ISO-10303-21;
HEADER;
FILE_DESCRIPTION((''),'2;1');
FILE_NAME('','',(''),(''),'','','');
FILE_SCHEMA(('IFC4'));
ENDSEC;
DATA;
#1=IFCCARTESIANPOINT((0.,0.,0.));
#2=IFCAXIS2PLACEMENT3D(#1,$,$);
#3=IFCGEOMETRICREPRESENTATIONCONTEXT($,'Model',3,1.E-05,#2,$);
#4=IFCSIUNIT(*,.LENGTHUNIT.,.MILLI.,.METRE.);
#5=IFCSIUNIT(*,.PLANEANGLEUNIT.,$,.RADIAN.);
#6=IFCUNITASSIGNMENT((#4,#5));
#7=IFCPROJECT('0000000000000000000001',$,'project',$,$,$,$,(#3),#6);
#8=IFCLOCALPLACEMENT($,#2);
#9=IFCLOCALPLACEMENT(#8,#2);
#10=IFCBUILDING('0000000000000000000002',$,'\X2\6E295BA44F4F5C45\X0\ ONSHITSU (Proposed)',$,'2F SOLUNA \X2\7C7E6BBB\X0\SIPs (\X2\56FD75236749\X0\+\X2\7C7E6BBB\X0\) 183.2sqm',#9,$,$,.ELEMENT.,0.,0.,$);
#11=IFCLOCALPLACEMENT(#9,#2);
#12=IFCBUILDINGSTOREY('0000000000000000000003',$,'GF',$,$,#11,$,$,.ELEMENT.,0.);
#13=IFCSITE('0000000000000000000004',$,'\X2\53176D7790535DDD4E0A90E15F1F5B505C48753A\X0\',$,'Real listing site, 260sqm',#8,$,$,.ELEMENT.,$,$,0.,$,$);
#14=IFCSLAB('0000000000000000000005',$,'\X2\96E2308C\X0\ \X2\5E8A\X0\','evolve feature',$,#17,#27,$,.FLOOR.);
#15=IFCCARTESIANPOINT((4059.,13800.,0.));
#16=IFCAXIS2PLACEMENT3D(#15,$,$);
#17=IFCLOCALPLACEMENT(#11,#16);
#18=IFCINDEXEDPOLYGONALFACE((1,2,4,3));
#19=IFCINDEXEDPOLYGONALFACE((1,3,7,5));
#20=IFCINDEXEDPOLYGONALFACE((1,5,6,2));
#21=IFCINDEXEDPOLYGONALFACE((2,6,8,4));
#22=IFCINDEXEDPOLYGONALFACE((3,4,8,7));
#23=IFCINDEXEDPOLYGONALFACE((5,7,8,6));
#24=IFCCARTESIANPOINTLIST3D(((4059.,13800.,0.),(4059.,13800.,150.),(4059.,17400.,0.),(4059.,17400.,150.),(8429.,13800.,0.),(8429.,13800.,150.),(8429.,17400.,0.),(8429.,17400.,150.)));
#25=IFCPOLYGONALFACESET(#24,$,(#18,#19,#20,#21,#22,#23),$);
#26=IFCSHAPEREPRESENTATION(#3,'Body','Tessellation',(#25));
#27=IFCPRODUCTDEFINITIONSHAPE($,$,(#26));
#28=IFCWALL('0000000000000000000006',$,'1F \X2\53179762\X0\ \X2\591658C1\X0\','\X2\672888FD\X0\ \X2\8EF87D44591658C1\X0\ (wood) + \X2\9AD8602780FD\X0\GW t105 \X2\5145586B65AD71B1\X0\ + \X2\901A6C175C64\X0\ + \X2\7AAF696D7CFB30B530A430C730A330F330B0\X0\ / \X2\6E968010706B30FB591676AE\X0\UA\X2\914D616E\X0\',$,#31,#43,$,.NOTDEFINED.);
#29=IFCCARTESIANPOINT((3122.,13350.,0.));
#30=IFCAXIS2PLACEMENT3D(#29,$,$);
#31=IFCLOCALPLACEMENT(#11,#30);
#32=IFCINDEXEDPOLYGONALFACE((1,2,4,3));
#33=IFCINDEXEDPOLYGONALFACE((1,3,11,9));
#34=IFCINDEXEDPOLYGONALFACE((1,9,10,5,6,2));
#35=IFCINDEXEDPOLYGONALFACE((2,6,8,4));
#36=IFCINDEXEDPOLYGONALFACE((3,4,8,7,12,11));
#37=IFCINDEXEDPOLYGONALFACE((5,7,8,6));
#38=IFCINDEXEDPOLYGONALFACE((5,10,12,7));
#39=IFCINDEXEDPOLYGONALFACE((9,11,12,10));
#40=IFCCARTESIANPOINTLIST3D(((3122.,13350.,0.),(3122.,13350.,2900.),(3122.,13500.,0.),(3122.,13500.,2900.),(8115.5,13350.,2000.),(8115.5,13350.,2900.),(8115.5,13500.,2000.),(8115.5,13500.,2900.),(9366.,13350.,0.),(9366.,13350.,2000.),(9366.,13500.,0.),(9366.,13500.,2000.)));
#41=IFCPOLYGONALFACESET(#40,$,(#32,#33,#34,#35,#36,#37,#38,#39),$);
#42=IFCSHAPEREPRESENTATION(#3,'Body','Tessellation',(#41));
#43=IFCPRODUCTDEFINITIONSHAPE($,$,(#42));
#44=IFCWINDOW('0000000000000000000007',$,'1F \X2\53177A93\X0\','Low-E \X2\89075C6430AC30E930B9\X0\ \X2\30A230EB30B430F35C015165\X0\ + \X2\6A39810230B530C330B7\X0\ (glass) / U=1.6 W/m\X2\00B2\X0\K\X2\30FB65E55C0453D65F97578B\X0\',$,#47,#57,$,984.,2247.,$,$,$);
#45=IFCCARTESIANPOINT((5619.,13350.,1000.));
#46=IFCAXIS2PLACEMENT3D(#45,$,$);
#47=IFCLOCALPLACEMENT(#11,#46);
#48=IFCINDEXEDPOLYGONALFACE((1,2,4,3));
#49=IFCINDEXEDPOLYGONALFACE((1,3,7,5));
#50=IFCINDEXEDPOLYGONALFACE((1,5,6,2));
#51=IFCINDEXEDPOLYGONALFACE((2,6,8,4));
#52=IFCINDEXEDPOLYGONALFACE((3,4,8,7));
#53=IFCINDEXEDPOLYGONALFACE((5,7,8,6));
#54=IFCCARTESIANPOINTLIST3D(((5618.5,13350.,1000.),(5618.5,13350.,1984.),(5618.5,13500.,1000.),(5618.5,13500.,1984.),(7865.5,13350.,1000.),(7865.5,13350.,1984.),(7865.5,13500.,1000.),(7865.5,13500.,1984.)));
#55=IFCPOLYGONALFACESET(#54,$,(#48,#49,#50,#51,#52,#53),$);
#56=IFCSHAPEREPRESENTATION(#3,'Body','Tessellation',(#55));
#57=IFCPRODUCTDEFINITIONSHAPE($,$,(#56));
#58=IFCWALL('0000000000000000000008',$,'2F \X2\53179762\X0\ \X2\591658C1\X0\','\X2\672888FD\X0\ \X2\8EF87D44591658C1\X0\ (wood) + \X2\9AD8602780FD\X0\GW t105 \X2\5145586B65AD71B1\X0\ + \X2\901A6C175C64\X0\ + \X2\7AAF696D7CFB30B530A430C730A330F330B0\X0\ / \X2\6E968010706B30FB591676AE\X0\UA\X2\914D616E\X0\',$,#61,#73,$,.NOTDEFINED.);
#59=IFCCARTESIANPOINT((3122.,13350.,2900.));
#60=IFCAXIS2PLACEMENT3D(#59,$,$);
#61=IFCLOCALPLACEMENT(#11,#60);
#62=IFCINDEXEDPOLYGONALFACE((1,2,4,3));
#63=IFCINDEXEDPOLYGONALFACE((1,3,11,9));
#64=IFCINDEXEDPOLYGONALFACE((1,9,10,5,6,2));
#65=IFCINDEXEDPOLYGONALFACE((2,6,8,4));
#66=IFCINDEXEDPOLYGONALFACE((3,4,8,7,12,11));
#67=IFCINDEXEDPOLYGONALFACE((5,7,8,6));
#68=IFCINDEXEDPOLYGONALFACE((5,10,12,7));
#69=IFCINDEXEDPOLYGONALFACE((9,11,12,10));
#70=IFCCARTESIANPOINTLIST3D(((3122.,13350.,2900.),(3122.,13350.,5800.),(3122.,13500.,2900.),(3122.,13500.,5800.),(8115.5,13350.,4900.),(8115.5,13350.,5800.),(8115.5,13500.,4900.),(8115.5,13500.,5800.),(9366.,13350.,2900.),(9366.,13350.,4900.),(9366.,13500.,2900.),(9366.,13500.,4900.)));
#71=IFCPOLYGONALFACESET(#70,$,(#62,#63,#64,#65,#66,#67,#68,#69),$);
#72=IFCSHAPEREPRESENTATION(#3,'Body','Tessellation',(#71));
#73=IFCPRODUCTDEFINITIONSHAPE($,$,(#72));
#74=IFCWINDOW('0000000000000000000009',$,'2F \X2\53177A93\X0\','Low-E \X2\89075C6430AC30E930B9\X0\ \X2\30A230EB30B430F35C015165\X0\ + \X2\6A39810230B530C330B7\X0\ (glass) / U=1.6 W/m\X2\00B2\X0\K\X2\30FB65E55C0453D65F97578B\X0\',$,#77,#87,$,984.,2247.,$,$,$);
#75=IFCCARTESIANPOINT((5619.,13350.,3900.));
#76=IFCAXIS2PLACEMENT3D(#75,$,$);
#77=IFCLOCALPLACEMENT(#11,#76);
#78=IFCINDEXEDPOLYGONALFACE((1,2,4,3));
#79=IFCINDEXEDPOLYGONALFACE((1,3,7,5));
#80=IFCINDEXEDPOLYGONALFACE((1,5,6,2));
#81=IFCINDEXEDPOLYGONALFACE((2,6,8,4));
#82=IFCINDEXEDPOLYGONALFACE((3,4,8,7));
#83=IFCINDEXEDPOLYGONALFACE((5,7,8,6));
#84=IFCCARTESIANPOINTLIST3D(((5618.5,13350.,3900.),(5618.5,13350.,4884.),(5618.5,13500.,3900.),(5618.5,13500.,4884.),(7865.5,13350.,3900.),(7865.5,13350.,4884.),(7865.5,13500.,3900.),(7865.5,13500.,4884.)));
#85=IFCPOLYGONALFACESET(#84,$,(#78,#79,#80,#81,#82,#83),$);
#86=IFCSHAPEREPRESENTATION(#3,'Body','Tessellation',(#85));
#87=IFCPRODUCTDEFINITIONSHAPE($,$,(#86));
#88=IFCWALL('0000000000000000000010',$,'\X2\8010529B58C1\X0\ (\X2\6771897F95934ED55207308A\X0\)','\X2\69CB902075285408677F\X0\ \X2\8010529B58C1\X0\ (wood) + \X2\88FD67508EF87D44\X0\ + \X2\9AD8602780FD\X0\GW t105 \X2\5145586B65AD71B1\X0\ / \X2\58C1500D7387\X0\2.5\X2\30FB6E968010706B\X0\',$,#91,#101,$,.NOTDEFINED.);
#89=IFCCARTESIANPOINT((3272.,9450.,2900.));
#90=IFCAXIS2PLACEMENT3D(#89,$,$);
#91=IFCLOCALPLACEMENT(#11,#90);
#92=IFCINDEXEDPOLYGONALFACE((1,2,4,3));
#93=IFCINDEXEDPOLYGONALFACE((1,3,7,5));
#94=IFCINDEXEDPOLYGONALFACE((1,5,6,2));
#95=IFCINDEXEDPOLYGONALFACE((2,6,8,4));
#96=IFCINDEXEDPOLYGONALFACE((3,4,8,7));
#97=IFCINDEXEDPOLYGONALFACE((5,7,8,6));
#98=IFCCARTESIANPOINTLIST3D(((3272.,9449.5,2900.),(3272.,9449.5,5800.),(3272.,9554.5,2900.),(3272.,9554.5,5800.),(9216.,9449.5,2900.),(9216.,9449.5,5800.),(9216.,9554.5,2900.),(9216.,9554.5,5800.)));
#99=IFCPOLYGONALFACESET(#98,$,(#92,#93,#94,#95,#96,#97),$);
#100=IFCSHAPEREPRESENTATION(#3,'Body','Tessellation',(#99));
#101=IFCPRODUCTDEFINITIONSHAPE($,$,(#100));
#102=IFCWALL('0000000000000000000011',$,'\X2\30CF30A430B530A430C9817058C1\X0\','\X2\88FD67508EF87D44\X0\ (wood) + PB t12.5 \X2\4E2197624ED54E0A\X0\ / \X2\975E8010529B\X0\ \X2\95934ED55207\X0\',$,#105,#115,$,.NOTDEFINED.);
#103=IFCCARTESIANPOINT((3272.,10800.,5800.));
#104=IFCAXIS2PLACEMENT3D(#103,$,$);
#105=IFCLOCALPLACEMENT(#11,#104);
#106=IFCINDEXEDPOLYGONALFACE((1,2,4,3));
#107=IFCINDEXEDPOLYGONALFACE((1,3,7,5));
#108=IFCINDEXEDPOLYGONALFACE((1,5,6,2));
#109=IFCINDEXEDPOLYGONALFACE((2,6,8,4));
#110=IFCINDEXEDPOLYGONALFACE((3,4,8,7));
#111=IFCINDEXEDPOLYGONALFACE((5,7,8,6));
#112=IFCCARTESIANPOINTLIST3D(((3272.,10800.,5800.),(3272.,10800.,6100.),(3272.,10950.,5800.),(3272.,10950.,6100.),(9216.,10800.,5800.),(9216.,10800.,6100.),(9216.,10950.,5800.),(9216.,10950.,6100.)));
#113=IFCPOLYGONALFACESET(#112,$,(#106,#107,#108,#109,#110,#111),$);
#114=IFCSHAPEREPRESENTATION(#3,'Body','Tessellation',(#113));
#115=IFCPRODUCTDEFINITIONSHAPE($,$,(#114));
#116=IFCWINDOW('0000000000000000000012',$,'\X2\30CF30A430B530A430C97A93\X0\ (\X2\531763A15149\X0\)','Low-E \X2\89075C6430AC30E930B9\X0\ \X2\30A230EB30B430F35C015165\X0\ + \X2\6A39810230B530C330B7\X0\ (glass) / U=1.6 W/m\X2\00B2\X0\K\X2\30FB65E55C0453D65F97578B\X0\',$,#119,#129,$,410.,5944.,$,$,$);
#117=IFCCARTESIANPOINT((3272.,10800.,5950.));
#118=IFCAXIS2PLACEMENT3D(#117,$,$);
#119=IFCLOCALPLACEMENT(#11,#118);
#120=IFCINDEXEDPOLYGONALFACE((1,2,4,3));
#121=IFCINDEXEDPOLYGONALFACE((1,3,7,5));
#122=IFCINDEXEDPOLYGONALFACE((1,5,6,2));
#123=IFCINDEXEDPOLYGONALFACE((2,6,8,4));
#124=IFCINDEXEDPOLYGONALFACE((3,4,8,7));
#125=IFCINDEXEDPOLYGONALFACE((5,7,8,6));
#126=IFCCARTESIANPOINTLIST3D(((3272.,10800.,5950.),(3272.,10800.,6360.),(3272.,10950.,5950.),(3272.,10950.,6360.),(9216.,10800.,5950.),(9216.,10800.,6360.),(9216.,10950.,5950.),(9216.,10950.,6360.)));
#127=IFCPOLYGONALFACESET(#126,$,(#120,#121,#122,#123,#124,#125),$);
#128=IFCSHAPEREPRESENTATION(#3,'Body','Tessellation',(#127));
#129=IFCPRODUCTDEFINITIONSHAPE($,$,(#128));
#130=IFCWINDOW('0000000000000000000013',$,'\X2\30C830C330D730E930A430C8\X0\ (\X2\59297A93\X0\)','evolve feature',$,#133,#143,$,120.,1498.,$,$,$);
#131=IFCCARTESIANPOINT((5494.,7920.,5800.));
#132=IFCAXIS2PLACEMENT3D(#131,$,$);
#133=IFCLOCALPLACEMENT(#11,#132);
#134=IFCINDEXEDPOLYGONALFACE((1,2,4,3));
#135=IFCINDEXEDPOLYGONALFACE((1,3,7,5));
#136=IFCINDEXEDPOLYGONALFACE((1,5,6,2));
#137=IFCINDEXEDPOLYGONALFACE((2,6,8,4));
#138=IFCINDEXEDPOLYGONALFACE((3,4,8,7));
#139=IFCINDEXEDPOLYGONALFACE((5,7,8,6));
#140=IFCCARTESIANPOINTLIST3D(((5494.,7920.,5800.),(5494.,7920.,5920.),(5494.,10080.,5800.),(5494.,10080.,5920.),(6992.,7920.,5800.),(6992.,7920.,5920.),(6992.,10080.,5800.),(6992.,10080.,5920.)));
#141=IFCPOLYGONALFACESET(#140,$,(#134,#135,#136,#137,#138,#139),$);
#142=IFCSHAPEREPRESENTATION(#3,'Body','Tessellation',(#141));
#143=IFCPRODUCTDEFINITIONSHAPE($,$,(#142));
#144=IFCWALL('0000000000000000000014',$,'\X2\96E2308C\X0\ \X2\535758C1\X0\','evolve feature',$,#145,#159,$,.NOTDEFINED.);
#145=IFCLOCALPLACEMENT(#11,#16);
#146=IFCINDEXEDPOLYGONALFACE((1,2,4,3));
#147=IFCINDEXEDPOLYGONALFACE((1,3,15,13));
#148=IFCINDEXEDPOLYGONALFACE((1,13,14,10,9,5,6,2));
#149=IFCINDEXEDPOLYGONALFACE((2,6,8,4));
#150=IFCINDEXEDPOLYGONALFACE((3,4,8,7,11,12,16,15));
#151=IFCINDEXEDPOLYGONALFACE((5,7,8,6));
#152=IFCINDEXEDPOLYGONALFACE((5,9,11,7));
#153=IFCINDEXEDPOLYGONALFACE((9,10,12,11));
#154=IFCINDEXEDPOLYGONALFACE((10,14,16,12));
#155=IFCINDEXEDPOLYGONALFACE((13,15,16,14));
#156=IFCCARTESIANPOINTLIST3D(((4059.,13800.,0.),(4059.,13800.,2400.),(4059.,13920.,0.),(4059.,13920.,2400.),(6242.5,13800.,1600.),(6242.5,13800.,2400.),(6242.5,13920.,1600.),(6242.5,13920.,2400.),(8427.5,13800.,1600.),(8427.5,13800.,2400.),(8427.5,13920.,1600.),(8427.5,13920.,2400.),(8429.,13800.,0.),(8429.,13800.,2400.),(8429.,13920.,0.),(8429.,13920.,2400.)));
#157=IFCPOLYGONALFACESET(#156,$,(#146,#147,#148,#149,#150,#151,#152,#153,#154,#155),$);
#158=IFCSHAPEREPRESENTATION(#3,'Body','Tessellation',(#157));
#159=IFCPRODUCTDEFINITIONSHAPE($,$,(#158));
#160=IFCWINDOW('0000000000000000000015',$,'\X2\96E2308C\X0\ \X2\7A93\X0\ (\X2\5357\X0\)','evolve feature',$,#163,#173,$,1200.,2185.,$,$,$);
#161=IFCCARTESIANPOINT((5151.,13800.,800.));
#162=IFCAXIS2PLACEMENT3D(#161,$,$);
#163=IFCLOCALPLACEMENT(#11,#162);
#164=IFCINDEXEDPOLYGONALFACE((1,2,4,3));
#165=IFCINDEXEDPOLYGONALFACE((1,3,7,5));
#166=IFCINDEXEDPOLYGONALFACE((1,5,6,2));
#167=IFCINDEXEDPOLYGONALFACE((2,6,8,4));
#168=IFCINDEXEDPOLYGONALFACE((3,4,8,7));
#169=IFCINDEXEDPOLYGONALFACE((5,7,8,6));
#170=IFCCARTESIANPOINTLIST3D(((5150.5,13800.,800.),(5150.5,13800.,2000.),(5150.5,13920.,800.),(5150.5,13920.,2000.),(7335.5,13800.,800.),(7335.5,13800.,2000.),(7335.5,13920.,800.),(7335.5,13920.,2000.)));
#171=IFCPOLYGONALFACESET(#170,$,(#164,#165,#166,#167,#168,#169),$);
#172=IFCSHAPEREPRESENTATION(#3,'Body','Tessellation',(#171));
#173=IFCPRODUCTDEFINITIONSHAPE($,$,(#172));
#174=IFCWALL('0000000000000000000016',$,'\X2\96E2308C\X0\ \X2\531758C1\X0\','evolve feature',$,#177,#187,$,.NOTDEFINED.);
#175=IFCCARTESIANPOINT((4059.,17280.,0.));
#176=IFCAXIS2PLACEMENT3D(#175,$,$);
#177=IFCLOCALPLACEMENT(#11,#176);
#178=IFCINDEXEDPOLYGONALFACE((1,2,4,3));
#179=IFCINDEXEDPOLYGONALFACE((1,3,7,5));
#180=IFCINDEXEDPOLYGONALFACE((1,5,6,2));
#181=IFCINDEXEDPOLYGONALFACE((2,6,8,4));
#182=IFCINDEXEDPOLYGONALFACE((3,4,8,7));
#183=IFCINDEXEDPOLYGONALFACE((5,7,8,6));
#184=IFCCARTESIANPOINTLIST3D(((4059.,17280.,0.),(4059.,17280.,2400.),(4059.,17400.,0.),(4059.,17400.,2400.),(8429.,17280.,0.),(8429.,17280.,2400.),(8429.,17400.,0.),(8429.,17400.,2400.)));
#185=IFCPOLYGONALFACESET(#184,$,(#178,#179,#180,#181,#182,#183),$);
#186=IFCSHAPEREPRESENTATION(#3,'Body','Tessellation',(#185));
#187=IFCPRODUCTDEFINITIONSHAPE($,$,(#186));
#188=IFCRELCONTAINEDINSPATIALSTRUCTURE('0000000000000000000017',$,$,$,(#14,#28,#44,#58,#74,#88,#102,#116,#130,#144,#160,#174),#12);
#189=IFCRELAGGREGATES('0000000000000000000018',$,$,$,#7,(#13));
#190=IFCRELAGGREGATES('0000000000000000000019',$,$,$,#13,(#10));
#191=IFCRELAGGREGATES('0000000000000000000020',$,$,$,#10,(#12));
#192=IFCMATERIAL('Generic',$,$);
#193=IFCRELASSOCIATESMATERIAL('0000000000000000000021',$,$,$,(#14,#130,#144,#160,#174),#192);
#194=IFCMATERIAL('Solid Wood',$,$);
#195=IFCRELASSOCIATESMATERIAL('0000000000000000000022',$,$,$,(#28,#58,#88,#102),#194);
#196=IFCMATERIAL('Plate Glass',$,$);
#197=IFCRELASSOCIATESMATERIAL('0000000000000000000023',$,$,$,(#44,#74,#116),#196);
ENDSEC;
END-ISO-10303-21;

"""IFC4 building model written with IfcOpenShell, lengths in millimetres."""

from ifc_helpers import new_model, si_unit, frame, frame_2d, origin, place, context, project, spatial, rectangle, extrude, material, element, fill, save


model = new_model("IFC4")

# Units and contexts
model_context = context("Model", 3, precision=1e-05, world=origin())
ifc_project = project(units=[si_unit("LENGTHUNIT", "METRE", prefix="MILLI"), si_unit("PLANEANGLEUNIT", "RADIAN")], contexts=[model_context])

# Site, building, storey
site_placement = place(None, origin())
site = spatial("IfcSite", under=ifc_project, at=site_placement, Name="北海道川上郡弟子屈町", ObjectType="Real listing site, 260sqm", CompositionType="ELEMENT", RefElevation=0.0)
building_placement = place(site_placement, origin())
building = spatial("IfcBuilding", under=site, at=building_placement, Name="温室住居 ONSHITSU (Proposed)", ObjectType="2F SOLUNA 籾殻SIPs (国産杉+籾殻) 183.2sqm", CompositionType="ELEMENT", ElevationOfRefHeight=0.0, ElevationOfTerrain=0.0)
storey_placement = place(building_placement, origin())
storey = spatial("IfcBuildingStorey", under=building, at=storey_placement, Name="GF", CompositionType="ELEMENT", Elevation=0.0)

# Slab
ifc_material_1 = material(Name="Generic")
slab_placement = place(storey_placement, frame((4059.0, 13800.0, 0.0)))
element("IfcSlab", 1, at=slab_placement, inside=storey, material=ifc_material_1, Name="離れ 床", Description="evolve feature", PredefinedType="FLOOR", context=model_context, shape_type="SweptSolid", body=[
    extrude(rectangle(XDim=4370.0, YDim=3600.0, at=frame_2d((2185.0, 1800.0))), frame((4059.0, 13800.0, 0.0)), (0.0, 0.0, 1.0), 150.0),
])

# Wall, opening, window
ifc_material_2 = material(Name="Solid Wood")
wall_1_placement = place(storey_placement, frame((3122.0, 13350.0, 0.0)))
wall_1 = element("IfcWall", 2, at=wall_1_placement, inside=storey, material=ifc_material_2, Name="1F 北面 外壁", Description="木製 軸組外壁 (wood) + 高性能GW t105 充填断熱 + 通気層 + 窯業系サイディング / 準耐火・外皮UA配慮", PredefinedType="NOTDEFINED", context=model_context, shape_type="SweptSolid", body=[
    extrude(rectangle(XDim=6244.0, YDim=150.0, at=frame_2d((3122.0, 75.0))), frame((3122.0, 13350.0, 0.0)), (0.0, 0.0, 1.0), 2900.0),
])
opening_1_placement = place(storey_placement, frame((5619.0, 13350.0, 1000.0)))
opening_1 = element("IfcOpeningElement", 3, at=opening_1_placement, cuts=wall_1, PredefinedType="NOTDEFINED", context=model_context, shape_type="SweptSolid", body=[
    extrude(rectangle(XDim=2247.0, YDim=150.0, at=frame_2d((1123.0, 75.0))), frame((5619.0, 13350.0, 1000.0)), (0.0, 0.0, 1.0), 984.0),
])
ifc_material_3 = material(Name="Plate Glass")
window_1_placement = place(storey_placement, frame((5619.0, 13350.0, 1000.0)))
window_1 = element("IfcWindow", 4, at=window_1_placement, inside=storey, material=ifc_material_3, Name="1F 北窓", Description="Low-E 複層ガラス アルゴン封入 + 樹脂サッシ (glass) / U=1.6 W/m²K・日射取得型", OverallHeight=984.0, OverallWidth=2247.0, context=model_context, shape_type="SweptSolid", body=[
    extrude(rectangle(XDim=2247.0, YDim=150.0, at=frame_2d((1123.0, 75.0))), frame((5619.0, 13350.0, 1000.0)), (0.0, 0.0, 1.0), 984.0),
])
fill(opening_1, window_1)

# Wall, opening, window
wall_2_placement = place(storey_placement, frame((3122.0, 13350.0, 2900.0)))
wall_2 = element("IfcWall", 5, at=wall_2_placement, inside=storey, material=ifc_material_2, Name="2F 北面 外壁", Description="木製 軸組外壁 (wood) + 高性能GW t105 充填断熱 + 通気層 + 窯業系サイディング / 準耐火・外皮UA配慮", PredefinedType="NOTDEFINED", context=model_context, shape_type="SweptSolid", body=[
    extrude(rectangle(XDim=6244.0, YDim=150.0, at=frame_2d((3122.0, 75.0))), frame((3122.0, 13350.0, 2900.0)), (0.0, 0.0, 1.0), 2900.0),
])
opening_2_placement = place(storey_placement, frame((5619.0, 13350.0, 3900.0)))
opening_2 = element("IfcOpeningElement", 6, at=opening_2_placement, cuts=wall_2, PredefinedType="NOTDEFINED", context=model_context, shape_type="SweptSolid", body=[
    extrude(rectangle(XDim=2247.0, YDim=150.0, at=frame_2d((1123.0, 75.0))), frame((5619.0, 13350.0, 3900.0)), (0.0, 0.0, 1.0), 984.0),
])
window_2_placement = place(storey_placement, frame((5619.0, 13350.0, 3900.0)))
window_2 = element("IfcWindow", 7, at=window_2_placement, inside=storey, material=ifc_material_3, Name="2F 北窓", Description="Low-E 複層ガラス アルゴン封入 + 樹脂サッシ (glass) / U=1.6 W/m²K・日射取得型", OverallHeight=984.0, OverallWidth=2247.0, context=model_context, shape_type="SweptSolid", body=[
    extrude(rectangle(XDim=2247.0, YDim=150.0, at=frame_2d((1123.0, 75.0))), frame((5619.0, 13350.0, 3900.0)), (0.0, 0.0, 1.0), 984.0),
])
fill(opening_2, window_2)

# Wall
wall_3_placement = place(storey_placement, frame((3272.0, 9450.0, 2900.0)))
element("IfcWall", 8, at=wall_3_placement, inside=storey, material=ifc_material_2, Name="耐力壁 (東西間仕切り)", Description="構造用合板 耐力壁 (wood) + 製材軸組 + 高性能GW t105 充填断熱 / 壁倍率2.5・準耐火", PredefinedType="NOTDEFINED", context=model_context, shape_type="SweptSolid", body=[
    extrude(rectangle(XDim=5944.0, YDim=105.0, at=frame_2d((2972.0, 52.0))), frame((3272.0, 9450.0, 2900.0)), (0.0, 0.0, 1.0), 2900.0),
])

# Wall, opening, window
wall_4_placement = place(storey_placement, frame((3272.0, 10800.0, 5800.0)))
wall_4 = element("IfcWall", 9, at=wall_4_placement, inside=storey, material=ifc_material_2, Name="ハイサイド腰壁", Description="製材軸組 (wood) + PB t12.5 両面仕上 / 非耐力 間仕切", PredefinedType="NOTDEFINED", context=model_context, shape_type="SweptSolid", body=[
    extrude(rectangle(XDim=5944.0, YDim=150.0, at=frame_2d((2972.0, 75.0))), frame((3272.0, 10800.0, 5800.0)), (0.0, 0.0, 1.0), 700.0),
])
opening_3_placement = place(storey_placement, frame((3272.0, 10800.0, 5950.0)))
opening_3 = element("IfcOpeningElement", 10, at=opening_3_placement, cuts=wall_4, PredefinedType="NOTDEFINED", context=model_context, shape_type="SweptSolid", body=[
    extrude(rectangle(XDim=5944.0, YDim=150.0, at=frame_2d((2972.0, 75.0))), frame((3272.0, 10800.0, 5950.0)), (0.0, 0.0, 1.0), 410.0),
])
window_3_placement = place(storey_placement, frame((3272.0, 10800.0, 5950.0)))
window_3 = element("IfcWindow", 11, at=window_3_placement, inside=storey, material=ifc_material_3, Name="ハイサイド窓 (北採光)", Description="Low-E 複層ガラス アルゴン封入 + 樹脂サッシ (glass) / U=1.6 W/m²K・日射取得型", OverallHeight=410.0, OverallWidth=5944.0, context=model_context, shape_type="SweptSolid", body=[
    extrude(rectangle(XDim=5944.0, YDim=150.0, at=frame_2d((2972.0, 75.0))), frame((3272.0, 10800.0, 5950.0)), (0.0, 0.0, 1.0), 410.0),
])
fill(opening_3, window_3)

# Window
window_4_placement = place(storey_placement, frame((5494.0, 7920.0, 5800.0)))
element("IfcWindow", 12, at=window_4_placement, inside=storey, material=ifc_material_1, Name="トップライト (天窓)", Description="evolve feature", OverallHeight=120.0, OverallWidth=1498.0, context=model_context, shape_type="SweptSolid", body=[
    extrude(rectangle(XDim=1498.0, YDim=2160.0, at=frame_2d((749.0, 1080.0))), frame((5494.0, 7920.0, 5800.0)), (0.0, 0.0, 1.0), 120.0),
])

# Wall, opening, window
wall_5_placement = place(storey_placement, frame((4059.0, 13800.0, 0.0)))
wall_5 = element("IfcWall", 13, at=wall_5_placement, inside=storey, material=ifc_material_1, Name="離れ 南壁", Description="evolve feature", PredefinedType="NOTDEFINED", context=model_context, shape_type="SweptSolid", body=[
    extrude(rectangle(XDim=4370.0, YDim=120.0, at=frame_2d((2185.0, 60.0))), frame((4059.0, 13800.0, 0.0)), (0.0, 0.0, 1.0), 2400.0),
])
opening_4_placement = place(storey_placement, frame((5151.0, 13800.0, 800.0)))
opening_4 = element("IfcOpeningElement", 14, at=opening_4_placement, cuts=wall_5, PredefinedType="NOTDEFINED", context=model_context, shape_type="SweptSolid", body=[
    extrude(rectangle(XDim=2185.0, YDim=120.0, at=frame_2d((1092.0, 60.0))), frame((5151.0, 13800.0, 800.0)), (0.0, 0.0, 1.0), 1200.0),
])
window_5_placement = place(storey_placement, frame((5151.0, 13800.0, 800.0)))
window_5 = element("IfcWindow", 15, at=window_5_placement, inside=storey, material=ifc_material_1, Name="離れ 窓 (南)", Description="evolve feature", OverallHeight=1200.0, OverallWidth=2185.0, context=model_context, shape_type="SweptSolid", body=[
    extrude(rectangle(XDim=2185.0, YDim=120.0, at=frame_2d((1092.0, 60.0))), frame((5151.0, 13800.0, 800.0)), (0.0, 0.0, 1.0), 1200.0),
])
fill(opening_4, window_5)

# Wall
wall_6_placement = place(storey_placement, frame((4059.0, 17280.0, 0.0)))
element("IfcWall", 16, at=wall_6_placement, inside=storey, material=ifc_material_1, Name="離れ 北壁", Description="evolve feature", PredefinedType="NOTDEFINED", context=model_context, shape_type="SweptSolid", body=[
    extrude(rectangle(XDim=4370.0, YDim=120.0, at=frame_2d((2185.0, 60.0))), frame((4059.0, 17280.0, 0.0)), (0.0, 0.0, 1.0), 2400.0),
])

save(model, "model.ifc")
